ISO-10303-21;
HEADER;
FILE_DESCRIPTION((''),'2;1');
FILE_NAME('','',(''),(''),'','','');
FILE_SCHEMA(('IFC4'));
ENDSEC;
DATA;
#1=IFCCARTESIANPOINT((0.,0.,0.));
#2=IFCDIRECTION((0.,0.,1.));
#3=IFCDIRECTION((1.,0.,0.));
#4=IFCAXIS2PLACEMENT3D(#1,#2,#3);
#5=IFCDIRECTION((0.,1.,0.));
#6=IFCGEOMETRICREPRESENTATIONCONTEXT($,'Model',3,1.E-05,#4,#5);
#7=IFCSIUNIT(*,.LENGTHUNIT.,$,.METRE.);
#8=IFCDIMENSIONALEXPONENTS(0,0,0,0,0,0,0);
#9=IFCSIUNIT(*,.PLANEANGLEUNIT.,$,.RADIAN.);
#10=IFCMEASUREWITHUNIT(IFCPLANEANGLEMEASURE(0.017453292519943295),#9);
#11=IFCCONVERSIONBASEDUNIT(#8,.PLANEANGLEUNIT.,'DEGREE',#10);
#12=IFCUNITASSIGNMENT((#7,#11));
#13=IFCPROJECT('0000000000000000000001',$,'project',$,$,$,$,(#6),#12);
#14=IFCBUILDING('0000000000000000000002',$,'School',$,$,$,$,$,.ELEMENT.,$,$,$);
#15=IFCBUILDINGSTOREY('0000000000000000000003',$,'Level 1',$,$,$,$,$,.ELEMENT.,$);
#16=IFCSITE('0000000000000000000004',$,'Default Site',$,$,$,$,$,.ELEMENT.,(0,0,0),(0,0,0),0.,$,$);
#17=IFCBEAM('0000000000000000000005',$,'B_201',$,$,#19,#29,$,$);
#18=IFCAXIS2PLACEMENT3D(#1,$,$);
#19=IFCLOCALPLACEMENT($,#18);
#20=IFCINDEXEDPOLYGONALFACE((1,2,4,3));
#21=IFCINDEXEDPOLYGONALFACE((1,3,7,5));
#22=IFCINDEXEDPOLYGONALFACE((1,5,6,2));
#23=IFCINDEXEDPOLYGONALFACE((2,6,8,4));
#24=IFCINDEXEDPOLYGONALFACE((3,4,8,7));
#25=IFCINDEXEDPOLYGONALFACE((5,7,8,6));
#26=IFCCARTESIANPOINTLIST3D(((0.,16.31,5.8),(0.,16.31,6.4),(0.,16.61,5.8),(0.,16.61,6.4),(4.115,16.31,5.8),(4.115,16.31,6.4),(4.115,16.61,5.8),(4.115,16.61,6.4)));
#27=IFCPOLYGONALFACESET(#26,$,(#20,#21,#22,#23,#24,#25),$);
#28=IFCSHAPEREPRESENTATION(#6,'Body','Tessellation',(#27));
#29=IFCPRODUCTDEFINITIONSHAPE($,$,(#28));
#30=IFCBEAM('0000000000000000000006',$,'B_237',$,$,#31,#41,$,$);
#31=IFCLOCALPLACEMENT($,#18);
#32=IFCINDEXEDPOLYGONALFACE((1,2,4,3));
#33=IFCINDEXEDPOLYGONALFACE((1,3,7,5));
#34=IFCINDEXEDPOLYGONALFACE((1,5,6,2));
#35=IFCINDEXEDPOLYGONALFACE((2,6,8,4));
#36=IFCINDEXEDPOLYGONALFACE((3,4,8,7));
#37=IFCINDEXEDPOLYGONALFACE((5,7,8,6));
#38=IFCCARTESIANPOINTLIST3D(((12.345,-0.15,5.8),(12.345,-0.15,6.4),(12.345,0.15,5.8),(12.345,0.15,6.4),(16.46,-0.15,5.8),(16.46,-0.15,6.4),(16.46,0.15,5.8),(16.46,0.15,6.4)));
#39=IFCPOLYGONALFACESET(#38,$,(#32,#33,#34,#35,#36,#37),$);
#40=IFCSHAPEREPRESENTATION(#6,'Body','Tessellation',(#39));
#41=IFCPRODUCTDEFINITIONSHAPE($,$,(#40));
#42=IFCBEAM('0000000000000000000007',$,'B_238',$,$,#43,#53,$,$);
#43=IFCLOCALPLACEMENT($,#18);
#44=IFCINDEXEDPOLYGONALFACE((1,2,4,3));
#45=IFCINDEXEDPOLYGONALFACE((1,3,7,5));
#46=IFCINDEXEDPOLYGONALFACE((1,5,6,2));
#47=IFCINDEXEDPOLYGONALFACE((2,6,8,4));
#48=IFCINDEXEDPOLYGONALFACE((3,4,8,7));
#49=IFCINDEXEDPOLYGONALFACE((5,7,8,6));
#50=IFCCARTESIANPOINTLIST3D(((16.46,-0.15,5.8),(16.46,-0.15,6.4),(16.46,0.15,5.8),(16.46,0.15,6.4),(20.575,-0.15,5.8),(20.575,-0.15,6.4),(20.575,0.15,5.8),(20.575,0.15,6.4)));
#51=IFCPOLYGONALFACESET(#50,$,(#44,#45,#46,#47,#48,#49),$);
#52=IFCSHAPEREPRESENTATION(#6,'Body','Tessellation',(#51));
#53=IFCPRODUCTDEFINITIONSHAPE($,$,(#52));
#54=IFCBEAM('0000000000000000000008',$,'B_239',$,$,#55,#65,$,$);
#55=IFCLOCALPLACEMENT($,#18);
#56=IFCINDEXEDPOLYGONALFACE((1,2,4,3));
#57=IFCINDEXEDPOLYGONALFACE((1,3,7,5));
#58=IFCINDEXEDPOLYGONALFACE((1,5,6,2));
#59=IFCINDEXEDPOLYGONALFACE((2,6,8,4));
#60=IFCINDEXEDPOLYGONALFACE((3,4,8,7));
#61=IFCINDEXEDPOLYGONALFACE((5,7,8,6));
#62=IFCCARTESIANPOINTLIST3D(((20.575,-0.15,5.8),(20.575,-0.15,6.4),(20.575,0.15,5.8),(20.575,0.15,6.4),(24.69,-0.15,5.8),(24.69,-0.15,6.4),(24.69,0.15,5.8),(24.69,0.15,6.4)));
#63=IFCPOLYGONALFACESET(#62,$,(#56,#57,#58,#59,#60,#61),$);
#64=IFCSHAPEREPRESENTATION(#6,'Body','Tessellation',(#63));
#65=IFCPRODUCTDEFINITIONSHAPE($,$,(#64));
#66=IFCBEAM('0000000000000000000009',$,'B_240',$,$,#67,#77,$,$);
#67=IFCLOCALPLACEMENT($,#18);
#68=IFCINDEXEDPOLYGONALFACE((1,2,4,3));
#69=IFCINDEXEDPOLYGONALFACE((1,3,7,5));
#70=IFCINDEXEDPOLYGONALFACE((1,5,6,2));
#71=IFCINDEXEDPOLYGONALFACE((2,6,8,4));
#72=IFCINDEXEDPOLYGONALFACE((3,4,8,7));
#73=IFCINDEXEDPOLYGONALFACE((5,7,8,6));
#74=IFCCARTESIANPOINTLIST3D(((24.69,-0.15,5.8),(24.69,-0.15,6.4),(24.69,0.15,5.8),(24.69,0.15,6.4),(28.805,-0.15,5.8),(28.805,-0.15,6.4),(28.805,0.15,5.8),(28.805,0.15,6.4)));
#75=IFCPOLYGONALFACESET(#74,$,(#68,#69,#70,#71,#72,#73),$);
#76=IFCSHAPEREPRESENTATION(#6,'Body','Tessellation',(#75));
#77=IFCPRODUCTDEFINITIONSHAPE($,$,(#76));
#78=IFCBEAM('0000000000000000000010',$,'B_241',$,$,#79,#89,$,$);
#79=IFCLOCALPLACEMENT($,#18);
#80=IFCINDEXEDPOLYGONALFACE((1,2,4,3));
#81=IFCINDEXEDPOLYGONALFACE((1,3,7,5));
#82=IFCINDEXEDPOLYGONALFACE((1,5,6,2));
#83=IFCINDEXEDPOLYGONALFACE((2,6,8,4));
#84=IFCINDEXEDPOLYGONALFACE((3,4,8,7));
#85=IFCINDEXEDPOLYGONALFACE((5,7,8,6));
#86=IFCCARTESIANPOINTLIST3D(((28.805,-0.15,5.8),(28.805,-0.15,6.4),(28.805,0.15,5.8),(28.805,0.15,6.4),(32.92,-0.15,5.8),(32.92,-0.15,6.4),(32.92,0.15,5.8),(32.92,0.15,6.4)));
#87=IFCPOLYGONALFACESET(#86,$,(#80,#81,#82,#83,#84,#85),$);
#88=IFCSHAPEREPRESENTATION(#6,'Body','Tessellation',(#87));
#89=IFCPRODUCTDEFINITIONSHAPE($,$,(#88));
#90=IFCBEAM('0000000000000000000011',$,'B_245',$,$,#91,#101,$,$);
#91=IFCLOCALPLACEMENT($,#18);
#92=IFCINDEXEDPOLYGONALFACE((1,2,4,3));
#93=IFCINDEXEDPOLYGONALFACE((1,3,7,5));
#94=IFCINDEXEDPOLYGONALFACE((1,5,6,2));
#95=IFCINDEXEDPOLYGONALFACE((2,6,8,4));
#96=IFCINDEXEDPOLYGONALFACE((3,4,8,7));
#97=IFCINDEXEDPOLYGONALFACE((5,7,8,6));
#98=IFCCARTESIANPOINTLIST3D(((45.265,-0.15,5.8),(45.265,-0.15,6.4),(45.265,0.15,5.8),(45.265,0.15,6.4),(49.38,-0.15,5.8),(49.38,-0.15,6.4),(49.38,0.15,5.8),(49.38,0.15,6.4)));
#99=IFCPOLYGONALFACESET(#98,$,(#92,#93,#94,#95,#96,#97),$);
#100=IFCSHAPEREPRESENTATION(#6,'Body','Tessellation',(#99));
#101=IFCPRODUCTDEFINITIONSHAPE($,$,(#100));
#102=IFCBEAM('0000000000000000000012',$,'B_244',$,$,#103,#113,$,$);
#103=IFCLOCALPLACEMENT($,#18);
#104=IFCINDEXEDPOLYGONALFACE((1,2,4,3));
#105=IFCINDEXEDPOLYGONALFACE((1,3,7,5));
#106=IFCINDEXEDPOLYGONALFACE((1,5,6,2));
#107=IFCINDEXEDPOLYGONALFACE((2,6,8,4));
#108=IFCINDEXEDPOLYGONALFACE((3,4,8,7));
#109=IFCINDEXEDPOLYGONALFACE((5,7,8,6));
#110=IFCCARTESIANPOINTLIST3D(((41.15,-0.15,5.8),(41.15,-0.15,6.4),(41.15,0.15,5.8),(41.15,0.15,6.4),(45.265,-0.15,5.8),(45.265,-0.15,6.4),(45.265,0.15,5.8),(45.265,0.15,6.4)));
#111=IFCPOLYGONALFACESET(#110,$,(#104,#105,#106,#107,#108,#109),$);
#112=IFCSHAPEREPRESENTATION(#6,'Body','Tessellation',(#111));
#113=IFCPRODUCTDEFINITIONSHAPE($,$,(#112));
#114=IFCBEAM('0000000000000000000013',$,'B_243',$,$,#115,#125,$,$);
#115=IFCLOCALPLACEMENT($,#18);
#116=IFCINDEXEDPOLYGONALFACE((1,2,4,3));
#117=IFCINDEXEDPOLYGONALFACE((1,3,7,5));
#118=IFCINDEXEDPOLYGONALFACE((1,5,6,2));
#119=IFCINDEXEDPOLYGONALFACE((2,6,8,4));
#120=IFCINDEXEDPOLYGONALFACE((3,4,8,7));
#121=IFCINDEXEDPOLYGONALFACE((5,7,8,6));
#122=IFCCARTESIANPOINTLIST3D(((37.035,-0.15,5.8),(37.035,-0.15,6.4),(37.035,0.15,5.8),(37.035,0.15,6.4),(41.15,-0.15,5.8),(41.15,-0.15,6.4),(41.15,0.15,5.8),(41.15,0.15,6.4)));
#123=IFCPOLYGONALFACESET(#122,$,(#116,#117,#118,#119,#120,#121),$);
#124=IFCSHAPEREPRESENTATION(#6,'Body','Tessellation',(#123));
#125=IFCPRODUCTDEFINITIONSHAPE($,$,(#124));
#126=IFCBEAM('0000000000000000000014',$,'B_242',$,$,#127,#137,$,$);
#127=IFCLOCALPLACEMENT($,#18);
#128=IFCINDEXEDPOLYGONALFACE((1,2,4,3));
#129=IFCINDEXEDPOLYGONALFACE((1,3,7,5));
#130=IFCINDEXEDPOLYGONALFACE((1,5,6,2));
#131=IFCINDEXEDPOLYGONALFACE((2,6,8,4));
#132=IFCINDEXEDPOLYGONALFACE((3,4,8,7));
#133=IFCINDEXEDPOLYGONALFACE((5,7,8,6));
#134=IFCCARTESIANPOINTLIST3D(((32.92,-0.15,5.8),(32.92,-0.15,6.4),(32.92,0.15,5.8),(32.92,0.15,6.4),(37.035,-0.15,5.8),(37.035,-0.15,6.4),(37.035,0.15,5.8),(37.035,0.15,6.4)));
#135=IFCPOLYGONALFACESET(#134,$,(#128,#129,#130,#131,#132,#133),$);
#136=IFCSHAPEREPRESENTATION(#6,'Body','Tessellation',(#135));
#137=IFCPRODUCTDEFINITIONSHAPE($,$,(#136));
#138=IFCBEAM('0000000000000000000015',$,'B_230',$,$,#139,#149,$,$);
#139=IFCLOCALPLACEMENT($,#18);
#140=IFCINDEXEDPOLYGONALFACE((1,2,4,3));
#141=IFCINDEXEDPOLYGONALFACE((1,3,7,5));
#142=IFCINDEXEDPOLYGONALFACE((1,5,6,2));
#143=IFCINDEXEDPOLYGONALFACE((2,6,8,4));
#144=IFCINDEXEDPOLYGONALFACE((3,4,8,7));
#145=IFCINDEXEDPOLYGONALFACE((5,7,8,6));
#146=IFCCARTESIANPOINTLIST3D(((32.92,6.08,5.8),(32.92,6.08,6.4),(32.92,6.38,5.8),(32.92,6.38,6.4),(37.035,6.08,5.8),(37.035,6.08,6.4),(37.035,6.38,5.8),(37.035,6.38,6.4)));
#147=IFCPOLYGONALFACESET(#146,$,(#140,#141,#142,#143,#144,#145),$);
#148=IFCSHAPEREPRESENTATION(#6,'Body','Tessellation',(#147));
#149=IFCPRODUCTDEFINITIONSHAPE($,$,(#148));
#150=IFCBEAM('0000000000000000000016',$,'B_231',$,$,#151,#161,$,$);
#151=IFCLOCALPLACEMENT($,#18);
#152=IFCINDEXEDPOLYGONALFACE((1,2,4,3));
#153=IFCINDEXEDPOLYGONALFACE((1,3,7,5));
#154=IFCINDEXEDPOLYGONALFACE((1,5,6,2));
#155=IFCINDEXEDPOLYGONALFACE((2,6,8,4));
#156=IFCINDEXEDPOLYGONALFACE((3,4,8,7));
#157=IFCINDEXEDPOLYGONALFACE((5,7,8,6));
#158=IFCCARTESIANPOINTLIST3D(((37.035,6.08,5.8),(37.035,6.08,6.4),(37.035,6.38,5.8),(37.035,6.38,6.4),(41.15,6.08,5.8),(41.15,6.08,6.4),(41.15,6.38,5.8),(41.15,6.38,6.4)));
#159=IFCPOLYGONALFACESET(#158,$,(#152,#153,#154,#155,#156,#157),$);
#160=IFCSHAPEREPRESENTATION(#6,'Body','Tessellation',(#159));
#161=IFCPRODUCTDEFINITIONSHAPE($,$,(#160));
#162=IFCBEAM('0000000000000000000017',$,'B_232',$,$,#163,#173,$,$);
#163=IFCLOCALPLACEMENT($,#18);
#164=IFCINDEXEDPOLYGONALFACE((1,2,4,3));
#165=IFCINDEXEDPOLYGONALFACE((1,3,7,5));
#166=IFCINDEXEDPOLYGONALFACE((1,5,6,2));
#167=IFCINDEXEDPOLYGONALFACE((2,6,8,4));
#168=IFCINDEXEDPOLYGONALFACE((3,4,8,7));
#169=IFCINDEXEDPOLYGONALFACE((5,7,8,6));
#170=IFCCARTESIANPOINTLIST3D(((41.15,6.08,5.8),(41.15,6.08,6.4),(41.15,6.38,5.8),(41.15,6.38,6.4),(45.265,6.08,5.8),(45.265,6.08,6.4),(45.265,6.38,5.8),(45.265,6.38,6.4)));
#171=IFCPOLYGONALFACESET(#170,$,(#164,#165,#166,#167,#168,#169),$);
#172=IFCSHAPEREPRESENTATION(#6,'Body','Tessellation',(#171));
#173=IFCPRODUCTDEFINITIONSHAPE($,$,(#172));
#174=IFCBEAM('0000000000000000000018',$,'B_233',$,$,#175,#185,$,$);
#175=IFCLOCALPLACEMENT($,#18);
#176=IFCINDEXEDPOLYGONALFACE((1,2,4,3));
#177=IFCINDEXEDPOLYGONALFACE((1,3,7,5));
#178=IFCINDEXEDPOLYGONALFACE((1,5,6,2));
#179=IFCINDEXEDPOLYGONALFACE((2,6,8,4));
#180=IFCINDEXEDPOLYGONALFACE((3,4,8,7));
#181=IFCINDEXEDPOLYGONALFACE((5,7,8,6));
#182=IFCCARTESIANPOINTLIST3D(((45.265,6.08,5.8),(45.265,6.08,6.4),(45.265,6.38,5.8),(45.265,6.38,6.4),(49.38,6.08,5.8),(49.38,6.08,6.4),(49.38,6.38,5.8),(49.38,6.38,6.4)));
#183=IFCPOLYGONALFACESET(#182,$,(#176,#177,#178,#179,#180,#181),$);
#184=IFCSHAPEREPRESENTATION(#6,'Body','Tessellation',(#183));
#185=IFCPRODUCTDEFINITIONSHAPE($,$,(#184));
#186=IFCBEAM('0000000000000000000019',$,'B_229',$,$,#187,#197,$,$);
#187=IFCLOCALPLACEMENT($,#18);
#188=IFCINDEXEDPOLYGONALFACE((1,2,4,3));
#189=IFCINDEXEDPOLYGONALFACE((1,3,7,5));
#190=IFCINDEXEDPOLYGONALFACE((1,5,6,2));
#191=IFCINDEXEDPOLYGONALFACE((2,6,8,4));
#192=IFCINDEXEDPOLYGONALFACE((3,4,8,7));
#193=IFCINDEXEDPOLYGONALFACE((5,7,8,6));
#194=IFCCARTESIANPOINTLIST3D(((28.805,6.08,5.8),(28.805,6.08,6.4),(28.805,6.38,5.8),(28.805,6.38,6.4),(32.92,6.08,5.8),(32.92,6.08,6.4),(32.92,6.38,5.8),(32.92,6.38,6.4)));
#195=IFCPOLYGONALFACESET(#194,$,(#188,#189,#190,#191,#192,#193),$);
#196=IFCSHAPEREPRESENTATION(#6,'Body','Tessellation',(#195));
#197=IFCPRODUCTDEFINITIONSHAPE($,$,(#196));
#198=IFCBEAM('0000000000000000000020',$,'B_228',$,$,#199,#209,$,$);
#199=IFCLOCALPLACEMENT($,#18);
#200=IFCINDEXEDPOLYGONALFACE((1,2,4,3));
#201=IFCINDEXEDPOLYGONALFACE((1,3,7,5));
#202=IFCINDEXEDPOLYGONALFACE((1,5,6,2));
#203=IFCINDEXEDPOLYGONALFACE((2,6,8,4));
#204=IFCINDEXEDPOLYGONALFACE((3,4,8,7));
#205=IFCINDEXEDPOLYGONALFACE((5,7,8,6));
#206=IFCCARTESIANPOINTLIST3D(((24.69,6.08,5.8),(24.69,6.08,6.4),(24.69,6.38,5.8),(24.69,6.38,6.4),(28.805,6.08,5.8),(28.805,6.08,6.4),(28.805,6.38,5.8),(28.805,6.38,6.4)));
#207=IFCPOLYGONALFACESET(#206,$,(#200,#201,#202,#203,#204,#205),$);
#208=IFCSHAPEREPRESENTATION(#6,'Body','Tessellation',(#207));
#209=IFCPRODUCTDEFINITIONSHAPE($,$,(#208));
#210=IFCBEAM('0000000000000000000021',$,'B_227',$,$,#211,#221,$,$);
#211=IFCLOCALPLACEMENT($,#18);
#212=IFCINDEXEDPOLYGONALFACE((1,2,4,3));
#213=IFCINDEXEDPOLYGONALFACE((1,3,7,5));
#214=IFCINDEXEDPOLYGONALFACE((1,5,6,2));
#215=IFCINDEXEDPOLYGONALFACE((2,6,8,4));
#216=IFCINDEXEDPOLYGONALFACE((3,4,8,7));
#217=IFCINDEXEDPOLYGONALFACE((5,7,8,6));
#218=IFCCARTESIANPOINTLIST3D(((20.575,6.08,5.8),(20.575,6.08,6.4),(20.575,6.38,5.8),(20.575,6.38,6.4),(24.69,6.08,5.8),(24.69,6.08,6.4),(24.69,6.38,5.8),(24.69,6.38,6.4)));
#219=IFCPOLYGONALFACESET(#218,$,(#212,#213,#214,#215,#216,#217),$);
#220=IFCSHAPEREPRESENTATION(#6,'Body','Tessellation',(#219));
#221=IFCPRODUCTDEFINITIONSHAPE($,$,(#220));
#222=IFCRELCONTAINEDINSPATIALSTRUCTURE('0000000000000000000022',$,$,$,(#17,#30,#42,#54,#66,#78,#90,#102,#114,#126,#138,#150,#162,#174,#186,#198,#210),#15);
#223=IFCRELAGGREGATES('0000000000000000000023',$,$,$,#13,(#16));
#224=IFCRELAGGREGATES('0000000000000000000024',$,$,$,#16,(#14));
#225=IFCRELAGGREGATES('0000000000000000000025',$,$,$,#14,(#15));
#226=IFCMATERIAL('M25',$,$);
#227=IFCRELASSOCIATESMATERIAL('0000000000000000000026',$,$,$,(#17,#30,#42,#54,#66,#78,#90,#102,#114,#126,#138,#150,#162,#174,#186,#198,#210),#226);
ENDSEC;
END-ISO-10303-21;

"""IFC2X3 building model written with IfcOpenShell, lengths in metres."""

from ifc_helpers import new_model, entity, si_unit, converted_unit, direction, frame, frame_2d, origin_with_axes, place, context, project, spatial, rectangle, extrude, material, element, save


model = new_model("IFC2X3")

# Units and contexts
model_context = context("Model", 3, precision=1e-05, world=origin_with_axes(), true_north=direction((0.0, 1.0, 0.0)))
ifc_project = project(units=[si_unit("LENGTHUNIT", "METRE"), converted_unit("PLANEANGLEUNIT", "DEGREE", entity("IfcPlaneAngleMeasure", 0.017453292519943295), si_unit("PLANEANGLEUNIT", "RADIAN"), dimensions=[0, 0, 0, 0, 0, 0, 0])], contexts=[model_context])

# Site, building, storey
site = spatial("IfcSite", under=ifc_project, Name="Default Site", CompositionType="ELEMENT", RefLatitude=(0, 0, 0), RefLongitude=(0, 0, 0), RefElevation=0.0)
building = spatial("IfcBuilding", under=site, Name="School", CompositionType="ELEMENT")
storey = spatial("IfcBuildingStorey", under=building, Name="Level 1", CompositionType="ELEMENT")

# Beams
ifc_material = material(Name="M25")
placement = place(None, origin_with_axes())
element("IfcBeam", 1, at=placement, inside=storey, material=ifc_material, Name="B_201", context=model_context, shape_type="SweptSolid", body=[
    extrude(rectangle(XDim=0.3, YDim=0.6, at=frame_2d((0.0, 0.0), x_axis=(0.0, 1.0, 0.0))), frame((0.0, 16.46, 6.1), z_axis=(1.0, 0.0, 0.0), x_axis=(0.0, 0.0, -1.0)), (0.0, 0.0, 1.0), 4.115),
])
element("IfcBeam", 2, at=placement, inside=storey, material=ifc_material, Name="B_237", context=model_context, shape_type="SweptSolid", body=[
    extrude(rectangle(XDim=0.3, YDim=0.6, at=frame_2d((0.0, 0.0), x_axis=(0.0, 1.0, 0.0))), frame((12.345, 0.0, 6.1), z_axis=(1.0, 0.0, 0.0), x_axis=(0.0, 0.0, -1.0)), (0.0, 0.0, 1.0), 4.115),
])
element("IfcBeam", 3, at=placement, inside=storey, material=ifc_material, Name="B_238", context=model_context, shape_type="SweptSolid", body=[
    extrude(rectangle(XDim=0.3, YDim=0.6, at=frame_2d((0.0, 0.0), x_axis=(0.0, 1.0, 0.0))), frame((16.46, 0.0, 6.1), z_axis=(1.0, 0.0, 0.0), x_axis=(0.0, 0.0, -1.0)), (0.0, 0.0, 1.0), 4.115),
])
element("IfcBeam", 4, at=placement, inside=storey, material=ifc_material, Name="B_239", context=model_context, shape_type="SweptSolid", body=[
    extrude(rectangle(XDim=0.3, YDim=0.6, at=frame_2d((0.0, 0.0), x_axis=(0.0, 1.0, 0.0))), frame((20.575, 0.0, 6.1), z_axis=(1.0, 0.0, 0.0), x_axis=(0.0, 0.0, -1.0)), (0.0, 0.0, 1.0), 4.115),
])
element("IfcBeam", 5, at=placement, inside=storey, material=ifc_material, Name="B_240", context=model_context, shape_type="SweptSolid", body=[
    extrude(rectangle(XDim=0.3, YDim=0.6, at=frame_2d((0.0, 0.0), x_axis=(0.0, 1.0, 0.0))), frame((24.69, 0.0, 6.1), z_axis=(1.0, 0.0, 0.0), x_axis=(0.0, 0.0, -1.0)), (0.0, 0.0, 1.0), 4.115),
])
element("IfcBeam", 6, at=placement, inside=storey, material=ifc_material, Name="B_241", context=model_context, shape_type="SweptSolid", body=[
    extrude(rectangle(XDim=0.3, YDim=0.6, at=frame_2d((0.0, 0.0), x_axis=(0.0, 1.0, 0.0))), frame((28.805, 0.0, 6.1), z_axis=(1.0, 0.0, 0.0), x_axis=(0.0, 0.0, -1.0)), (0.0, 0.0, 1.0), 4.115),
])
element("IfcBeam", 7, at=placement, inside=storey, material=ifc_material, Name="B_245", context=model_context, shape_type="SweptSolid", body=[
    extrude(rectangle(XDim=0.3, YDim=0.6, at=frame_2d((0.0, 0.0), x_axis=(0.0, 1.0, 0.0))), frame((45.265, 0.0, 6.1), z_axis=(1.0, 0.0, 0.0), x_axis=(0.0, 0.0, -1.0)), (0.0, 0.0, 1.0), 4.115),
])
element("IfcBeam", 8, at=placement, inside=storey, material=ifc_material, Name="B_244", context=model_context, shape_type="SweptSolid", body=[
    extrude(rectangle(XDim=0.3, YDim=0.6, at=frame_2d((0.0, 0.0), x_axis=(0.0, 1.0, 0.0))), frame((41.15, 0.0, 6.1), z_axis=(1.0, 0.0, 0.0), x_axis=(0.0, 0.0, -1.0)), (0.0, 0.0, 1.0), 4.115),
])
element("IfcBeam", 9, at=placement, inside=storey, material=ifc_material, Name="B_243", context=model_context, shape_type="SweptSolid", body=[
    extrude(rectangle(XDim=0.3, YDim=0.6, at=frame_2d((0.0, 0.0), x_axis=(0.0, 1.0, 0.0))), frame((37.035, 0.0, 6.1), z_axis=(1.0, 0.0, 0.0), x_axis=(0.0, 0.0, -1.0)), (0.0, 0.0, 1.0), 4.115),
])
element("IfcBeam", 10, at=placement, inside=storey, material=ifc_material, Name="B_242", context=model_context, shape_type="SweptSolid", body=[
    extrude(rectangle(XDim=0.3, YDim=0.6, at=frame_2d((0.0, 0.0), x_axis=(0.0, 1.0, 0.0))), frame((32.92, 0.0, 6.1), z_axis=(1.0, 0.0, 0.0), x_axis=(0.0, 0.0, -1.0)), (0.0, 0.0, 1.0), 4.115),
])
element("IfcBeam", 11, at=placement, inside=storey, material=ifc_material, Name="B_230", context=model_context, shape_type="SweptSolid", body=[
    extrude(rectangle(XDim=0.3, YDim=0.6, at=frame_2d((0.0, 0.0), x_axis=(0.0, 1.0, 0.0))), frame((32.92, 6.23, 6.1), z_axis=(1.0, 0.0, 0.0), x_axis=(0.0, 0.0, -1.0)), (0.0, 0.0, 1.0), 4.115),
])
element("IfcBeam", 12, at=placement, inside=storey, material=ifc_material, Name="B_231", context=model_context, shape_type="SweptSolid", body=[
    extrude(rectangle(XDim=0.3, YDim=0.6, at=frame_2d((0.0, 0.0), x_axis=(0.0, 1.0, 0.0))), frame((37.035, 6.23, 6.1), z_axis=(1.0, 0.0, 0.0), x_axis=(0.0, 0.0, -1.0)), (0.0, 0.0, 1.0), 4.115),
])
element("IfcBeam", 13, at=placement, inside=storey, material=ifc_material, Name="B_232", context=model_context, shape_type="SweptSolid", body=[
    extrude(rectangle(XDim=0.3, YDim=0.6, at=frame_2d((0.0, 0.0), x_axis=(0.0, 1.0, 0.0))), frame((41.15, 6.23, 6.1), z_axis=(1.0, 0.0, 0.0), x_axis=(0.0, 0.0, -1.0)), (0.0, 0.0, 1.0), 4.115),
])
element("IfcBeam", 14, at=placement, inside=storey, material=ifc_material, Name="B_233", context=model_context, shape_type="SweptSolid", body=[
    extrude(rectangle(XDim=0.3, YDim=0.6, at=frame_2d((0.0, 0.0), x_axis=(0.0, 1.0, 0.0))), frame((45.265, 6.23, 6.1), z_axis=(1.0, 0.0, 0.0), x_axis=(0.0, 0.0, -1.0)), (0.0, 0.0, 1.0), 4.115),
])
element("IfcBeam", 15, at=placement, inside=storey, material=ifc_material, Name="B_229", context=model_context, shape_type="SweptSolid", body=[
    extrude(rectangle(XDim=0.3, YDim=0.6, at=frame_2d((0.0, 0.0), x_axis=(0.0, 1.0, 0.0))), frame((28.805, 6.23, 6.1), z_axis=(1.0, 0.0, 0.0), x_axis=(0.0, 0.0, -1.0)), (0.0, 0.0, 1.0), 4.115),
])
element("IfcBeam", 16, at=placement, inside=storey, material=ifc_material, Name="B_228", context=model_context, shape_type="SweptSolid", body=[
    extrude(rectangle(XDim=0.3, YDim=0.6, at=frame_2d((0.0, 0.0), x_axis=(0.0, 1.0, 0.0))), frame((24.69, 6.23, 6.1), z_axis=(1.0, 0.0, 0.0), x_axis=(0.0, 0.0, -1.0)), (0.0, 0.0, 1.0), 4.115),
])
element("IfcBeam", 17, at=placement, inside=storey, material=ifc_material, Name="B_227", context=model_context, shape_type="SweptSolid", body=[
    extrude(rectangle(XDim=0.3, YDim=0.6, at=frame_2d((0.0, 0.0), x_axis=(0.0, 1.0, 0.0))), frame((20.575, 6.23, 6.1), z_axis=(1.0, 0.0, 0.0), x_axis=(0.0, 0.0, -1.0)), (0.0, 0.0, 1.0), 4.115),
])

save(model, "model.ifc")
